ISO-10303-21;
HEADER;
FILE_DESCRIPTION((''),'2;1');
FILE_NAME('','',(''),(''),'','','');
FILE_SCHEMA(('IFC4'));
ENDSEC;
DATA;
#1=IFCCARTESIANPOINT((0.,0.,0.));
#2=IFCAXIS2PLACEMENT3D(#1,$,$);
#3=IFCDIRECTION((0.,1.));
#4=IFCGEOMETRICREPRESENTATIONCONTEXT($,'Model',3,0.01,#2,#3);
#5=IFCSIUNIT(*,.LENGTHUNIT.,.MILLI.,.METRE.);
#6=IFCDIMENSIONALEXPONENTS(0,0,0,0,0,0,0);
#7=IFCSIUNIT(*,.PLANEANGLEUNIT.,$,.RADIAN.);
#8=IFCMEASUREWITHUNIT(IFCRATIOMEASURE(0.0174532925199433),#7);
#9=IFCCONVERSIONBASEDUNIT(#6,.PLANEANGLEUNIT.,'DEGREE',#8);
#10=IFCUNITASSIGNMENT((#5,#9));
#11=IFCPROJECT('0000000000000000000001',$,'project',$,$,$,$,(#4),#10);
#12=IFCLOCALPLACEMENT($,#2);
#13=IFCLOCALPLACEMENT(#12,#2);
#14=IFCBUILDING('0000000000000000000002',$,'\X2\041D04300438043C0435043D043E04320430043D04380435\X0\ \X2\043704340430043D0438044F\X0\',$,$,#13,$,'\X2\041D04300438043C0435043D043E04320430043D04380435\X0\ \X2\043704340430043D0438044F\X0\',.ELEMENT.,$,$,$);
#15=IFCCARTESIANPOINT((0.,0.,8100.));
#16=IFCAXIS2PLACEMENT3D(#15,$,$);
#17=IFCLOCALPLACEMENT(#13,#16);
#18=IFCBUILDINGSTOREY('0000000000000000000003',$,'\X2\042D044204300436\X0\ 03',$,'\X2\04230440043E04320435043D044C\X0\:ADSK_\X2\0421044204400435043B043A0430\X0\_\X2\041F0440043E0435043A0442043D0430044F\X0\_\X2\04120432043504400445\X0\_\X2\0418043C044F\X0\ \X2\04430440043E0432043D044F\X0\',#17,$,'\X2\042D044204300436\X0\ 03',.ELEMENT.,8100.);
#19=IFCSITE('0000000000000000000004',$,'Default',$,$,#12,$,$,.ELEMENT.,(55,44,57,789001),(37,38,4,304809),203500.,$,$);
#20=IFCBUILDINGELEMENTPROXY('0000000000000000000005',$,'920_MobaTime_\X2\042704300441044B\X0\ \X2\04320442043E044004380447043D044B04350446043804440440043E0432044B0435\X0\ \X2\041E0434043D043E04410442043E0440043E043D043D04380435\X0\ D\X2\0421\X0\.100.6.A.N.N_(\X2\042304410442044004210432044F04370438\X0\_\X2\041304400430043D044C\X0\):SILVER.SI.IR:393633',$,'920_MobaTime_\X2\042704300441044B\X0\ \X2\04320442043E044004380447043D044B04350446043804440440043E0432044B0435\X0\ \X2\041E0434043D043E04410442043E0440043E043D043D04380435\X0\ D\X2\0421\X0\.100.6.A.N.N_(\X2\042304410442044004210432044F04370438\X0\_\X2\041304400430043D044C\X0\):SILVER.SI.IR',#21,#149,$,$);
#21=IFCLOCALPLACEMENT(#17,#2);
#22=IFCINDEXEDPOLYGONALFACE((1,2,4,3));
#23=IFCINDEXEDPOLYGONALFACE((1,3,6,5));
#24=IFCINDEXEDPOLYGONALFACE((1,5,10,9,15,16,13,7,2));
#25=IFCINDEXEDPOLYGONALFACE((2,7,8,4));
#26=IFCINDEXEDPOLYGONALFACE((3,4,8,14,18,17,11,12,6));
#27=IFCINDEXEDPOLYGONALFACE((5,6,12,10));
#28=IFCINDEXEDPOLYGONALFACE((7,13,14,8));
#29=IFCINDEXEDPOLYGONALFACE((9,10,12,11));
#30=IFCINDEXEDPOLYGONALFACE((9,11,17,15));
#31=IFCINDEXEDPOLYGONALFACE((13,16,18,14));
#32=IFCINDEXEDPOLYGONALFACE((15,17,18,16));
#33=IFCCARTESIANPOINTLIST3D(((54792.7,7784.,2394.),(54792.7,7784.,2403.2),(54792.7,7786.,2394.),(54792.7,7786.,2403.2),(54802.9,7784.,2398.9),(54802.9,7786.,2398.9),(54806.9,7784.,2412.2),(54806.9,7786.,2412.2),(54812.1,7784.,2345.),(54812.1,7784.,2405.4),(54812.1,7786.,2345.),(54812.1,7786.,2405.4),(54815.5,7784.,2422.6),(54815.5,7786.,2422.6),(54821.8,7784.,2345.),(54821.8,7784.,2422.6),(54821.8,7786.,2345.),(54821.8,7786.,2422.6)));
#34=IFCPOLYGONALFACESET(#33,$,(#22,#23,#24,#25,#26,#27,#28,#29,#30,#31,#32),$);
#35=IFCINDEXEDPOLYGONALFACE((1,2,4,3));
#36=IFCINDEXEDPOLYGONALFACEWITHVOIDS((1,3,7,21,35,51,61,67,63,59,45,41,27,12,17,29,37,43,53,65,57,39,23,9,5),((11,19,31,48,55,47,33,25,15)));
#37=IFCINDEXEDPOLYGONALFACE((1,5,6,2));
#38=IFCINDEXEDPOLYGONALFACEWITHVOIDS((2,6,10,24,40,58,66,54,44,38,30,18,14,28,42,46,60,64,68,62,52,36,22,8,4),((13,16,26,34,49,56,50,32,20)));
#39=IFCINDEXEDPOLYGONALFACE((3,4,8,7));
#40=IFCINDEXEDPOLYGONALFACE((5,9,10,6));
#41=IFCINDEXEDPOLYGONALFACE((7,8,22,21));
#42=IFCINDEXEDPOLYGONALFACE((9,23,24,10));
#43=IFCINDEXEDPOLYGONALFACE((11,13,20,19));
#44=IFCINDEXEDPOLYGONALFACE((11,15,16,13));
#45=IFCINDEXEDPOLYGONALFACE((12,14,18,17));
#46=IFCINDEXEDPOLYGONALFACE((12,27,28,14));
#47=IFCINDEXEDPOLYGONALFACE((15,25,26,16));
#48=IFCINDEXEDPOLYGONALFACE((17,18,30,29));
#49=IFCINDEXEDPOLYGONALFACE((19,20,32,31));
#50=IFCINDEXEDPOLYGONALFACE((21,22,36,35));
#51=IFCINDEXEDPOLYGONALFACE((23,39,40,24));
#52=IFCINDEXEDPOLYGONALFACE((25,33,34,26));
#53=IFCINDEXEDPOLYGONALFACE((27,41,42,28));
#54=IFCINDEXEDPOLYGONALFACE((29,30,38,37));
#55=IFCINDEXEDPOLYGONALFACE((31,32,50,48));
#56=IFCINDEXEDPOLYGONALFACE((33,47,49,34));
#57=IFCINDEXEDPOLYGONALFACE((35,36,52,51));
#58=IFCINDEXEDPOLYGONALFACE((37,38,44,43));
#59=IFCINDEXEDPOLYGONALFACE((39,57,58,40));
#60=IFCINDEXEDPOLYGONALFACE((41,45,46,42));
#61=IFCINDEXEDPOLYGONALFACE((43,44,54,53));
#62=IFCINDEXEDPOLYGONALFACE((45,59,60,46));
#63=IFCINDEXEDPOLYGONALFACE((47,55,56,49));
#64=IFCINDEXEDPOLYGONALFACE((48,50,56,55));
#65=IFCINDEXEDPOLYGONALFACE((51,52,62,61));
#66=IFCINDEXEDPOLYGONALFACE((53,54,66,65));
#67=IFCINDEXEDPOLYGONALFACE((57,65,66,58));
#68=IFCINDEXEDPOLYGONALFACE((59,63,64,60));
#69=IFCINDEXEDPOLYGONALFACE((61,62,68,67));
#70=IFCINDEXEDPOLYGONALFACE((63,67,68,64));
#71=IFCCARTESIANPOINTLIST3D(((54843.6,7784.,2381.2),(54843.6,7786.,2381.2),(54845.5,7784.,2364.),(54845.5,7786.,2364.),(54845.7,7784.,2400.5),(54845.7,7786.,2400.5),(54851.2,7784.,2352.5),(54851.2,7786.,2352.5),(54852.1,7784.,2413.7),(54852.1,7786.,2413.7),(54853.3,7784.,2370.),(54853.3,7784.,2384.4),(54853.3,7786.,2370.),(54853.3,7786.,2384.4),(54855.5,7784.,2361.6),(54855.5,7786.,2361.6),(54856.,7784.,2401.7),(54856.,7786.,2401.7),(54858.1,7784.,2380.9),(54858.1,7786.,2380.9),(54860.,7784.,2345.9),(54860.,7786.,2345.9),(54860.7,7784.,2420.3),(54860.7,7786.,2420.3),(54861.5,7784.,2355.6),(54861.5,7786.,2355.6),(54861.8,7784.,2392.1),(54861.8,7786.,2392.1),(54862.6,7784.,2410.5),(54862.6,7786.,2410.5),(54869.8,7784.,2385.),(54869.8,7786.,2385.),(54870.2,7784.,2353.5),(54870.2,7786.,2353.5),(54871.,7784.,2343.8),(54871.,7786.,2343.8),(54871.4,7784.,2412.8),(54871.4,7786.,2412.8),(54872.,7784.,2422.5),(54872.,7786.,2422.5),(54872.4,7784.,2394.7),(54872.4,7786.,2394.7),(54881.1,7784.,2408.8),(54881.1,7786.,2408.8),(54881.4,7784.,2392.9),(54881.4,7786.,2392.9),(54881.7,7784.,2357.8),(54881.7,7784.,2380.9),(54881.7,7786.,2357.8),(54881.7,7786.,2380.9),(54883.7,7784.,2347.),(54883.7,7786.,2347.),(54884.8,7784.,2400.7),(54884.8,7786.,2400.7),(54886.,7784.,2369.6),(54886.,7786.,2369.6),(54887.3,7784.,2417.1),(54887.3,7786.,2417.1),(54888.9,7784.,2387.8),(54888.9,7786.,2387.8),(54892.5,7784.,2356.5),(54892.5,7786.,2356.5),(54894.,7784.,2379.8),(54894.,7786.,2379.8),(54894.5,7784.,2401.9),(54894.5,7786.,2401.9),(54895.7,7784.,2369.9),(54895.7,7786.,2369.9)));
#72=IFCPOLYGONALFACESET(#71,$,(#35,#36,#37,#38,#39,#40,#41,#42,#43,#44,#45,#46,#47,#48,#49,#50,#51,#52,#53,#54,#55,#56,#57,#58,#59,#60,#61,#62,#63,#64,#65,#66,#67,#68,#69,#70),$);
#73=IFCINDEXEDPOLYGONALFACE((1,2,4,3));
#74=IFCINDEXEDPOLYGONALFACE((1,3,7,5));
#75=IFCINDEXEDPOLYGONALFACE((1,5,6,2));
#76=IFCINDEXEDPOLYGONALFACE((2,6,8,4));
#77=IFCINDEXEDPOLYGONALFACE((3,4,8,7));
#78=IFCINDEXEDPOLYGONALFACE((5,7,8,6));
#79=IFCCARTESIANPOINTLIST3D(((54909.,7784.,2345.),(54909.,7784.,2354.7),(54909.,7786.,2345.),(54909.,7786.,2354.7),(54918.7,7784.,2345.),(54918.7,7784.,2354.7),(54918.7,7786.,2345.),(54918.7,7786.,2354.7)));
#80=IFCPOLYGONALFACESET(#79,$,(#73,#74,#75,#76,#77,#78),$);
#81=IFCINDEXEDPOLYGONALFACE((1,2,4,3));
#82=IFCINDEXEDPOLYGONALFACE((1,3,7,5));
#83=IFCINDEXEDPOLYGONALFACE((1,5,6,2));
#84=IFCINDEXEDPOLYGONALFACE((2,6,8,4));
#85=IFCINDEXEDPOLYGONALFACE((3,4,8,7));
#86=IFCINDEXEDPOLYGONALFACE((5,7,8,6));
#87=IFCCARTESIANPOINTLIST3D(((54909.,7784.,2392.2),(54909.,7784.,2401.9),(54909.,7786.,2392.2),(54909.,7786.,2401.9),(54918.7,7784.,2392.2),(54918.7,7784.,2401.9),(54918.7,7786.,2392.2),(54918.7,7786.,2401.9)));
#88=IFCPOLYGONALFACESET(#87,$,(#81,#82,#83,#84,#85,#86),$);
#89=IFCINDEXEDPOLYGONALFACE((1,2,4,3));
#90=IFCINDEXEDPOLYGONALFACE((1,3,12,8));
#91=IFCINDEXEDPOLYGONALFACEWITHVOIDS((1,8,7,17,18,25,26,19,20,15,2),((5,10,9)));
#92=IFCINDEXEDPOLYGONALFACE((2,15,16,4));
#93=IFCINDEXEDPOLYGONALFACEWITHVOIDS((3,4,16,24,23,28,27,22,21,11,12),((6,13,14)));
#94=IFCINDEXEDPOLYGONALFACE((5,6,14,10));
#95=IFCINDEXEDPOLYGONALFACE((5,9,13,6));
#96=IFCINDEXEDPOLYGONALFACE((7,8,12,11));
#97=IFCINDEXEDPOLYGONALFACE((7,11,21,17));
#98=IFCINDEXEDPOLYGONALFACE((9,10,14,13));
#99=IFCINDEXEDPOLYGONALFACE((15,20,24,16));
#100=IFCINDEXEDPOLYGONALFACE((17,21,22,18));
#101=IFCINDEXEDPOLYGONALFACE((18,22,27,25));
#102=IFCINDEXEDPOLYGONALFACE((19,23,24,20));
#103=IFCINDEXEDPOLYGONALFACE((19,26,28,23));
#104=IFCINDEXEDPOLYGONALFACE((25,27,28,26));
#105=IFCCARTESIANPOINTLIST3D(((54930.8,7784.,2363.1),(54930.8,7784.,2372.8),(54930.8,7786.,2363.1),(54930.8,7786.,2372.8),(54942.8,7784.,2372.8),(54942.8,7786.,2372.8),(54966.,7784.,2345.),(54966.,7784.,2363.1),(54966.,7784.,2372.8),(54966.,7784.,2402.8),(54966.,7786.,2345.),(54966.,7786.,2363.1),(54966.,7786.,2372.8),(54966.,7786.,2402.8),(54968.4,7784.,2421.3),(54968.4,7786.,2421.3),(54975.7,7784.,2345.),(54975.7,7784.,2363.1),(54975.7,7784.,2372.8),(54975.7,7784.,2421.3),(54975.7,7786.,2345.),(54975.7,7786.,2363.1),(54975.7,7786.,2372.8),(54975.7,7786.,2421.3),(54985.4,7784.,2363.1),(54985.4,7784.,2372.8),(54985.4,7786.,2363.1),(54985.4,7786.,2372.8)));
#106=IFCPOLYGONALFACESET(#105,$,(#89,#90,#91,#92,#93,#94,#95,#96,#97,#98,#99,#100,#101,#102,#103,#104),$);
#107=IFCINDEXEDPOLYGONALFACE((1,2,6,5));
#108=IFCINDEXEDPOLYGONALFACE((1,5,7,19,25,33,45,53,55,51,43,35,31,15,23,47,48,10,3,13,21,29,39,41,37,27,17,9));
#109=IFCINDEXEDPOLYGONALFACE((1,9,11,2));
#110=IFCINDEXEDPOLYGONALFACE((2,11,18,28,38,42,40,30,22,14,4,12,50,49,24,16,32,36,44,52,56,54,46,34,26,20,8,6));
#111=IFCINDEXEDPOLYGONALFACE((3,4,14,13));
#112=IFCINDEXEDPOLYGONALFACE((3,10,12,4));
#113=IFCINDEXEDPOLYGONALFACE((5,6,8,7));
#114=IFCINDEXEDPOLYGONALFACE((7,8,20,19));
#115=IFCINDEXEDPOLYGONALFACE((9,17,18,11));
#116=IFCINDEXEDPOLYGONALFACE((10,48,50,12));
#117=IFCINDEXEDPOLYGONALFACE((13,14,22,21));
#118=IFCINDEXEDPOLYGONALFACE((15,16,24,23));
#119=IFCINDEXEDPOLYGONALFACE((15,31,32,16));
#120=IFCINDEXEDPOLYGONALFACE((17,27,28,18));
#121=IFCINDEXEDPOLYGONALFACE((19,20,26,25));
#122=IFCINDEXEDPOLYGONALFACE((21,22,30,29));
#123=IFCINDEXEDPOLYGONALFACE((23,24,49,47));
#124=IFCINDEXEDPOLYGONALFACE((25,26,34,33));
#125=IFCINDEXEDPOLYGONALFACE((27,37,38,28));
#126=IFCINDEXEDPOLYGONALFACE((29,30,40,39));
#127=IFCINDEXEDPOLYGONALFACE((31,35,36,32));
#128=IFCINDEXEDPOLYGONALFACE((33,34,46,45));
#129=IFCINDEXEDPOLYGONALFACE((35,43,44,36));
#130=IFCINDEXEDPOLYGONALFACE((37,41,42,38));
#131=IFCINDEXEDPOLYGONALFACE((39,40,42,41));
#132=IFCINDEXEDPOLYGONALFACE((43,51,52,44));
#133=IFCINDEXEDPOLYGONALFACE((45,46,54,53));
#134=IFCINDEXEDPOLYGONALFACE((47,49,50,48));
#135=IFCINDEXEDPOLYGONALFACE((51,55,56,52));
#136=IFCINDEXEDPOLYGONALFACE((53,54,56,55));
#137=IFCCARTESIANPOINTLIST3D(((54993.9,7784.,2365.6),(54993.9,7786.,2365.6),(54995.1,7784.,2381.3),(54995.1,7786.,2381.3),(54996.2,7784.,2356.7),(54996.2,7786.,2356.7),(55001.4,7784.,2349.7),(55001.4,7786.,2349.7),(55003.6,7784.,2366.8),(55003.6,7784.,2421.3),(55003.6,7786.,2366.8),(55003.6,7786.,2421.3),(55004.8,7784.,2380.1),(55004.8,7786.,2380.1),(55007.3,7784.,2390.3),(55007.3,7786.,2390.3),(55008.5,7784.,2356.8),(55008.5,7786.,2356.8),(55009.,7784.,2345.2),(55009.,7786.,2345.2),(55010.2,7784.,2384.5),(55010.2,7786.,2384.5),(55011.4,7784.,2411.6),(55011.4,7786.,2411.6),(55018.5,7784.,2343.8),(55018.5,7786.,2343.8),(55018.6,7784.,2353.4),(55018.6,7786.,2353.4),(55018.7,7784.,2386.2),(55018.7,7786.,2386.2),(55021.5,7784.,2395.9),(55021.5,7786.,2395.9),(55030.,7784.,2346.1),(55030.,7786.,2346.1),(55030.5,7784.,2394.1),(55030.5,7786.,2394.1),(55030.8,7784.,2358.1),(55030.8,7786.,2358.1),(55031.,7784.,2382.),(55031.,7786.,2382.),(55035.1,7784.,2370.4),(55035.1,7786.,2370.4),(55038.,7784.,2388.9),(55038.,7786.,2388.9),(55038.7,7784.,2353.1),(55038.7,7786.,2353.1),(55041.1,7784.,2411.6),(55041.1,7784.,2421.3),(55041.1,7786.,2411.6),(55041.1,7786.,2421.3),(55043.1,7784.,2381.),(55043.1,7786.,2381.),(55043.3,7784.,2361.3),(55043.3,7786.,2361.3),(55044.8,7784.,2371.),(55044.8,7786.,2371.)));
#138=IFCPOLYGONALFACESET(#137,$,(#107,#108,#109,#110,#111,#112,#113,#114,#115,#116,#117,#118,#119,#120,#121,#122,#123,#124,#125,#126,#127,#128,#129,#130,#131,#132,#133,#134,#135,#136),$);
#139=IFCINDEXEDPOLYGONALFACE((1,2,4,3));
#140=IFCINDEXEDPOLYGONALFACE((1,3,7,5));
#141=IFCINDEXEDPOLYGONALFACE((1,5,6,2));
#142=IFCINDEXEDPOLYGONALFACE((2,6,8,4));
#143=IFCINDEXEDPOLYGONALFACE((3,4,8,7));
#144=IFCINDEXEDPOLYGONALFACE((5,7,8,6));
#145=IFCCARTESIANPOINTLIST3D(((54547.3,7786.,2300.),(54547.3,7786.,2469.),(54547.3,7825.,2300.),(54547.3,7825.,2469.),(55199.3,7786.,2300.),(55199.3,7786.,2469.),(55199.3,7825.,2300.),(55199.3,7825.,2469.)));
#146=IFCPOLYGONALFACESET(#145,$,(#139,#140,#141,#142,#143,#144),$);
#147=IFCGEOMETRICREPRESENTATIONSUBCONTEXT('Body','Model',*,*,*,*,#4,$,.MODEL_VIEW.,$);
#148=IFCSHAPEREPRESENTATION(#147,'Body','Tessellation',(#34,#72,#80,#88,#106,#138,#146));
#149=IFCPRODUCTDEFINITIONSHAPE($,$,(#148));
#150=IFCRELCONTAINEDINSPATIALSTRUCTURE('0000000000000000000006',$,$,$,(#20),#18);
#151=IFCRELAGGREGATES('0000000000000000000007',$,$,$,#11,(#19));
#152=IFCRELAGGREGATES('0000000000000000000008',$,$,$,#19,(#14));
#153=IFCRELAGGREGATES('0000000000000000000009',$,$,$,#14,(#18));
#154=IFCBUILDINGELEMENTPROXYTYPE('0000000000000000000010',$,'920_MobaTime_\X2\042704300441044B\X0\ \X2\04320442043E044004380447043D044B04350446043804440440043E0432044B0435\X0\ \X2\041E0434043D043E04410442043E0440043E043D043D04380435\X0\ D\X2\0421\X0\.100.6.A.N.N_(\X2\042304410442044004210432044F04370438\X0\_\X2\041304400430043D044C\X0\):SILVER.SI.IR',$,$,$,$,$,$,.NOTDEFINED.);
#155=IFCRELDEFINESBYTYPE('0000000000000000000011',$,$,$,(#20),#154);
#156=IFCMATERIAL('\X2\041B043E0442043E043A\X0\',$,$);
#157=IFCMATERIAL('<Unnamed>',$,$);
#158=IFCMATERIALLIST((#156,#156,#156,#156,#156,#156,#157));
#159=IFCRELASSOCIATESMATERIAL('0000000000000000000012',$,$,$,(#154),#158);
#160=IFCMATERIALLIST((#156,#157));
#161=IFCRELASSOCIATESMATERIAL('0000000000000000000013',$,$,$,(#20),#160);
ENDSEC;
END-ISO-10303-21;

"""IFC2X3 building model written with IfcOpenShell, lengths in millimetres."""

from ifc_helpers import new_model, entity, si_unit, converted_unit, direction, frame, origin, origin_2d_with_axis, place, context, subcontext, project, spatial, polyline, rectangle, outline, extrude, source, transform, mapped, material, material_list, type_object, type_shapes, element, save


model = new_model("IFC2X3")

# Units and contexts
model_context = context("Model", 3, precision=0.01, world=origin(), true_north=direction((0.0, 1.0)))
body_context = subcontext(model_context, "Body", "Model", "MODEL_VIEW")
ifc_project = project(units=[si_unit("LENGTHUNIT", "METRE", prefix="MILLI"), converted_unit("PLANEANGLEUNIT", "DEGREE", entity("IfcRatioMeasure", 0.0174532925199433), si_unit("PLANEANGLEUNIT", "RADIAN"), dimensions=[0, 0, 0, 0, 0, 0, 0])], contexts=[model_context])

# Site, building, storey
site_placement = place(None, origin())
site = spatial("IfcSite", under=ifc_project, at=site_placement, Name="Default", CompositionType="ELEMENT", RefLatitude=(55, 44, 57, 789001), RefLongitude=(37, 38, 4, 304809), RefElevation=203500.0)
building_placement = place(site_placement, origin())
building = spatial("IfcBuilding", under=site, at=building_placement, Name="Наименование здания", LongName="Наименование здания", CompositionType="ELEMENT")
storey_placement = place(building_placement, frame((0.0, 0.0, 8100.0)))
storey = spatial("IfcBuildingStorey", under=building, at=storey_placement, Name="Этаж 03", ObjectType="Уровень:ADSK_Стрелка_Проектная_Вверх_Имя уровня", LongName="Этаж 03", CompositionType="ELEMENT", Elevation=8100.0)

# Building element proxy
ifc_material_1 = material(Name="Лоток")
ifc_material_2 = material(Name="<Unnamed>")
ifc_material_list_1 = material_list([ifc_material_1, ifc_material_1, ifc_material_1, ifc_material_1, ifc_material_1, ifc_material_1, ifc_material_2])
building_element_proxy_type = type_object("IfcBuildingElementProxyType", Name="920_MobaTime_Часы вторичныецифровые Односторонние DС.100.6.A.N.N_(УстрСвязи_Грань):SILVER.SI.IR", PredefinedType="NOTDEFINED", material=ifc_material_list_1)
shared_shape = source(origin(), body_context, "Body", "SweptSolid", [
    extrude(outline(polyline([(-49.3, -13.1), (28.2, -13.1), (28.2, -6.8), (17.9, 1.8), (8.8, 16.0), (-0.3, 16.0), (4.6, 5.8), (11.1, -3.4), (-49.3, -3.4), (-49.3, -13.1)])), frame((-64.6, 9.8, 39.0), z_axis=(0.0, 0.0, 1.0), x_axis=(0.0, 1.0, 0.0)), (0.0, 0.0, 1.0), 2.0),
    extrude(outline(polyline([(2.2, -27.6), (19.0, -27.6), (30.5, -16.1), (33.3, -4.9), (31.0, 5.8), (21.8, 17.2), (5.2, 27.3), (-11.1, 33.0), (-24.0, 32.7), (-33.6, 27.6), (-40.3, 18.6), (-42.8, 5.7), (-38.0, -6.3), (-27.2, -14.9), (-17.5, -17.7), (-8.2, -16.4), (-0.3, -11.9), (5.1, -4.5), (7.3, 6.2), (4.0, 17.2), (18.4, 7.3), (23.6, -2.4), (22.0, -11.4), (14.2, -18.4), (5.3, -18.3), (2.2, -27.6)]), holes=[polyline([(-9.0, 23.3), (-1.3, 14.3), (-2.5, 2.0), (-11.4, -7.0), (-23.4, -6.0), (-32.2, 2.9), (-31.2, 15.1), (-25.6, 22.1), (-17.5, 24.9), (-9.0, 23.3)])]), frame((-2.7, 3.6, 39.0), z_axis=(0.0, 0.0, 1.0), x_axis=(-0.427649, 0.903945, 0.0)), (0.0, 0.0, 1.0), 2.0),
    extrude(rectangle(XDim=9.7, YDim=9.7, at=origin_2d_with_axis()), frame((40.6, -34.7, 39.0)), (0.0, 0.0, 1.0), 2.0),
    extrude(rectangle(XDim=9.7, YDim=9.7, at=origin_2d_with_axis()), frame((40.6, 12.6, 39.0)), (0.0, 0.0, 1.0), 2.0),
    extrude(outline(polyline([(-0.9, -28.1), (8.8, -28.1), (8.8, -9.9), (18.5, -9.9), (18.5, -0.2), (8.8, -0.2), (8.8, 48.3), (1.5, 48.3), (-36.0, -0.2), (-36.0, -9.9), (-0.9, -9.9), (-0.9, -28.1)]), holes=[polyline([(-0.9, -0.2), (-24.1, -0.2), (-0.9, 29.7), (-0.9, -0.2)])]), frame((93.6, -11.4, 39.0)), (0.0, 0.0, 1.0), 2.0),
    extrude(outline(polyline([(3.3, -28.3), (12.5, -28.3), (20.5, -25.0), (26.8, -18.9), (30.7, -10.0), (31.4, 1.6), (26.9, 11.8), (20.1, 18.4), (11.1, 22.3), (1.0, 23.3), (-7.9, 20.4), (-14.9, 14.5), (-18.9, 6.2), (-17.1, -9.0), (-36.7, 0.5), (-29.1, 29.2), (-38.5, 31.7), (-48.1, -4.6), (-11.6, -23.1), (-8.0, -14.0), (-10.8, -7.6), (-10.2, 1.1), (-3.0, 11.8), (9.2, 12.8), (20.0, 5.5), (21.4, -7.5), (15.5, -16.4), (4.6, -18.6), (3.3, -28.3)])), frame((147.1, -8.5, 39.0), z_axis=(0.0, 0.0, 1.0), x_axis=(0.256974, -0.966418, 0.0)), (0.0, 0.0, 1.0), 2.0),
    extrude(rectangle(XDim=652.0, YDim=169.0, at=origin_2d_with_axis()), frame((0.0, 0.0, 0.0), z_axis=(0.0, 0.0, 1.0), x_axis=(-1.0, 0.0, 0.0)), (0.0, 0.0, 1.0), 39.0),
])
type_shapes(building_element_proxy_type, [shared_shape])
ifc_material_list_2 = material_list([ifc_material_1, ifc_material_2])
for number, where, z_axis, x_axis, name in (
    (1, (54873.3, 7825.0, 2384.5), (0.0, -1.0, 0.0), (1.0, 0.0, 0.0), "920_MobaTime_Часы вторичныецифровые Односторонние DС.100.6.A.N.N_(УстрСвязи_Грань):SILVER.SI.IR:393633"),
):
    element("IfcBuildingElementProxy", number, at=place(storey_placement, frame(where, z_axis=z_axis, x_axis=x_axis)), inside=storey, type_object=building_element_proxy_type, material=ifc_material_list_2, Name=name, ObjectType="920_MobaTime_Часы вторичныецифровые Односторонние DС.100.6.A.N.N_(УстрСвязи_Грань):SILVER.SI.IR", context=body_context, shape_type="MappedRepresentation", body=[
        mapped(shared_shape, transform((0.0, 0.0, 0.0), scale=1.0)),
    ])

save(model, "model.ifc")
